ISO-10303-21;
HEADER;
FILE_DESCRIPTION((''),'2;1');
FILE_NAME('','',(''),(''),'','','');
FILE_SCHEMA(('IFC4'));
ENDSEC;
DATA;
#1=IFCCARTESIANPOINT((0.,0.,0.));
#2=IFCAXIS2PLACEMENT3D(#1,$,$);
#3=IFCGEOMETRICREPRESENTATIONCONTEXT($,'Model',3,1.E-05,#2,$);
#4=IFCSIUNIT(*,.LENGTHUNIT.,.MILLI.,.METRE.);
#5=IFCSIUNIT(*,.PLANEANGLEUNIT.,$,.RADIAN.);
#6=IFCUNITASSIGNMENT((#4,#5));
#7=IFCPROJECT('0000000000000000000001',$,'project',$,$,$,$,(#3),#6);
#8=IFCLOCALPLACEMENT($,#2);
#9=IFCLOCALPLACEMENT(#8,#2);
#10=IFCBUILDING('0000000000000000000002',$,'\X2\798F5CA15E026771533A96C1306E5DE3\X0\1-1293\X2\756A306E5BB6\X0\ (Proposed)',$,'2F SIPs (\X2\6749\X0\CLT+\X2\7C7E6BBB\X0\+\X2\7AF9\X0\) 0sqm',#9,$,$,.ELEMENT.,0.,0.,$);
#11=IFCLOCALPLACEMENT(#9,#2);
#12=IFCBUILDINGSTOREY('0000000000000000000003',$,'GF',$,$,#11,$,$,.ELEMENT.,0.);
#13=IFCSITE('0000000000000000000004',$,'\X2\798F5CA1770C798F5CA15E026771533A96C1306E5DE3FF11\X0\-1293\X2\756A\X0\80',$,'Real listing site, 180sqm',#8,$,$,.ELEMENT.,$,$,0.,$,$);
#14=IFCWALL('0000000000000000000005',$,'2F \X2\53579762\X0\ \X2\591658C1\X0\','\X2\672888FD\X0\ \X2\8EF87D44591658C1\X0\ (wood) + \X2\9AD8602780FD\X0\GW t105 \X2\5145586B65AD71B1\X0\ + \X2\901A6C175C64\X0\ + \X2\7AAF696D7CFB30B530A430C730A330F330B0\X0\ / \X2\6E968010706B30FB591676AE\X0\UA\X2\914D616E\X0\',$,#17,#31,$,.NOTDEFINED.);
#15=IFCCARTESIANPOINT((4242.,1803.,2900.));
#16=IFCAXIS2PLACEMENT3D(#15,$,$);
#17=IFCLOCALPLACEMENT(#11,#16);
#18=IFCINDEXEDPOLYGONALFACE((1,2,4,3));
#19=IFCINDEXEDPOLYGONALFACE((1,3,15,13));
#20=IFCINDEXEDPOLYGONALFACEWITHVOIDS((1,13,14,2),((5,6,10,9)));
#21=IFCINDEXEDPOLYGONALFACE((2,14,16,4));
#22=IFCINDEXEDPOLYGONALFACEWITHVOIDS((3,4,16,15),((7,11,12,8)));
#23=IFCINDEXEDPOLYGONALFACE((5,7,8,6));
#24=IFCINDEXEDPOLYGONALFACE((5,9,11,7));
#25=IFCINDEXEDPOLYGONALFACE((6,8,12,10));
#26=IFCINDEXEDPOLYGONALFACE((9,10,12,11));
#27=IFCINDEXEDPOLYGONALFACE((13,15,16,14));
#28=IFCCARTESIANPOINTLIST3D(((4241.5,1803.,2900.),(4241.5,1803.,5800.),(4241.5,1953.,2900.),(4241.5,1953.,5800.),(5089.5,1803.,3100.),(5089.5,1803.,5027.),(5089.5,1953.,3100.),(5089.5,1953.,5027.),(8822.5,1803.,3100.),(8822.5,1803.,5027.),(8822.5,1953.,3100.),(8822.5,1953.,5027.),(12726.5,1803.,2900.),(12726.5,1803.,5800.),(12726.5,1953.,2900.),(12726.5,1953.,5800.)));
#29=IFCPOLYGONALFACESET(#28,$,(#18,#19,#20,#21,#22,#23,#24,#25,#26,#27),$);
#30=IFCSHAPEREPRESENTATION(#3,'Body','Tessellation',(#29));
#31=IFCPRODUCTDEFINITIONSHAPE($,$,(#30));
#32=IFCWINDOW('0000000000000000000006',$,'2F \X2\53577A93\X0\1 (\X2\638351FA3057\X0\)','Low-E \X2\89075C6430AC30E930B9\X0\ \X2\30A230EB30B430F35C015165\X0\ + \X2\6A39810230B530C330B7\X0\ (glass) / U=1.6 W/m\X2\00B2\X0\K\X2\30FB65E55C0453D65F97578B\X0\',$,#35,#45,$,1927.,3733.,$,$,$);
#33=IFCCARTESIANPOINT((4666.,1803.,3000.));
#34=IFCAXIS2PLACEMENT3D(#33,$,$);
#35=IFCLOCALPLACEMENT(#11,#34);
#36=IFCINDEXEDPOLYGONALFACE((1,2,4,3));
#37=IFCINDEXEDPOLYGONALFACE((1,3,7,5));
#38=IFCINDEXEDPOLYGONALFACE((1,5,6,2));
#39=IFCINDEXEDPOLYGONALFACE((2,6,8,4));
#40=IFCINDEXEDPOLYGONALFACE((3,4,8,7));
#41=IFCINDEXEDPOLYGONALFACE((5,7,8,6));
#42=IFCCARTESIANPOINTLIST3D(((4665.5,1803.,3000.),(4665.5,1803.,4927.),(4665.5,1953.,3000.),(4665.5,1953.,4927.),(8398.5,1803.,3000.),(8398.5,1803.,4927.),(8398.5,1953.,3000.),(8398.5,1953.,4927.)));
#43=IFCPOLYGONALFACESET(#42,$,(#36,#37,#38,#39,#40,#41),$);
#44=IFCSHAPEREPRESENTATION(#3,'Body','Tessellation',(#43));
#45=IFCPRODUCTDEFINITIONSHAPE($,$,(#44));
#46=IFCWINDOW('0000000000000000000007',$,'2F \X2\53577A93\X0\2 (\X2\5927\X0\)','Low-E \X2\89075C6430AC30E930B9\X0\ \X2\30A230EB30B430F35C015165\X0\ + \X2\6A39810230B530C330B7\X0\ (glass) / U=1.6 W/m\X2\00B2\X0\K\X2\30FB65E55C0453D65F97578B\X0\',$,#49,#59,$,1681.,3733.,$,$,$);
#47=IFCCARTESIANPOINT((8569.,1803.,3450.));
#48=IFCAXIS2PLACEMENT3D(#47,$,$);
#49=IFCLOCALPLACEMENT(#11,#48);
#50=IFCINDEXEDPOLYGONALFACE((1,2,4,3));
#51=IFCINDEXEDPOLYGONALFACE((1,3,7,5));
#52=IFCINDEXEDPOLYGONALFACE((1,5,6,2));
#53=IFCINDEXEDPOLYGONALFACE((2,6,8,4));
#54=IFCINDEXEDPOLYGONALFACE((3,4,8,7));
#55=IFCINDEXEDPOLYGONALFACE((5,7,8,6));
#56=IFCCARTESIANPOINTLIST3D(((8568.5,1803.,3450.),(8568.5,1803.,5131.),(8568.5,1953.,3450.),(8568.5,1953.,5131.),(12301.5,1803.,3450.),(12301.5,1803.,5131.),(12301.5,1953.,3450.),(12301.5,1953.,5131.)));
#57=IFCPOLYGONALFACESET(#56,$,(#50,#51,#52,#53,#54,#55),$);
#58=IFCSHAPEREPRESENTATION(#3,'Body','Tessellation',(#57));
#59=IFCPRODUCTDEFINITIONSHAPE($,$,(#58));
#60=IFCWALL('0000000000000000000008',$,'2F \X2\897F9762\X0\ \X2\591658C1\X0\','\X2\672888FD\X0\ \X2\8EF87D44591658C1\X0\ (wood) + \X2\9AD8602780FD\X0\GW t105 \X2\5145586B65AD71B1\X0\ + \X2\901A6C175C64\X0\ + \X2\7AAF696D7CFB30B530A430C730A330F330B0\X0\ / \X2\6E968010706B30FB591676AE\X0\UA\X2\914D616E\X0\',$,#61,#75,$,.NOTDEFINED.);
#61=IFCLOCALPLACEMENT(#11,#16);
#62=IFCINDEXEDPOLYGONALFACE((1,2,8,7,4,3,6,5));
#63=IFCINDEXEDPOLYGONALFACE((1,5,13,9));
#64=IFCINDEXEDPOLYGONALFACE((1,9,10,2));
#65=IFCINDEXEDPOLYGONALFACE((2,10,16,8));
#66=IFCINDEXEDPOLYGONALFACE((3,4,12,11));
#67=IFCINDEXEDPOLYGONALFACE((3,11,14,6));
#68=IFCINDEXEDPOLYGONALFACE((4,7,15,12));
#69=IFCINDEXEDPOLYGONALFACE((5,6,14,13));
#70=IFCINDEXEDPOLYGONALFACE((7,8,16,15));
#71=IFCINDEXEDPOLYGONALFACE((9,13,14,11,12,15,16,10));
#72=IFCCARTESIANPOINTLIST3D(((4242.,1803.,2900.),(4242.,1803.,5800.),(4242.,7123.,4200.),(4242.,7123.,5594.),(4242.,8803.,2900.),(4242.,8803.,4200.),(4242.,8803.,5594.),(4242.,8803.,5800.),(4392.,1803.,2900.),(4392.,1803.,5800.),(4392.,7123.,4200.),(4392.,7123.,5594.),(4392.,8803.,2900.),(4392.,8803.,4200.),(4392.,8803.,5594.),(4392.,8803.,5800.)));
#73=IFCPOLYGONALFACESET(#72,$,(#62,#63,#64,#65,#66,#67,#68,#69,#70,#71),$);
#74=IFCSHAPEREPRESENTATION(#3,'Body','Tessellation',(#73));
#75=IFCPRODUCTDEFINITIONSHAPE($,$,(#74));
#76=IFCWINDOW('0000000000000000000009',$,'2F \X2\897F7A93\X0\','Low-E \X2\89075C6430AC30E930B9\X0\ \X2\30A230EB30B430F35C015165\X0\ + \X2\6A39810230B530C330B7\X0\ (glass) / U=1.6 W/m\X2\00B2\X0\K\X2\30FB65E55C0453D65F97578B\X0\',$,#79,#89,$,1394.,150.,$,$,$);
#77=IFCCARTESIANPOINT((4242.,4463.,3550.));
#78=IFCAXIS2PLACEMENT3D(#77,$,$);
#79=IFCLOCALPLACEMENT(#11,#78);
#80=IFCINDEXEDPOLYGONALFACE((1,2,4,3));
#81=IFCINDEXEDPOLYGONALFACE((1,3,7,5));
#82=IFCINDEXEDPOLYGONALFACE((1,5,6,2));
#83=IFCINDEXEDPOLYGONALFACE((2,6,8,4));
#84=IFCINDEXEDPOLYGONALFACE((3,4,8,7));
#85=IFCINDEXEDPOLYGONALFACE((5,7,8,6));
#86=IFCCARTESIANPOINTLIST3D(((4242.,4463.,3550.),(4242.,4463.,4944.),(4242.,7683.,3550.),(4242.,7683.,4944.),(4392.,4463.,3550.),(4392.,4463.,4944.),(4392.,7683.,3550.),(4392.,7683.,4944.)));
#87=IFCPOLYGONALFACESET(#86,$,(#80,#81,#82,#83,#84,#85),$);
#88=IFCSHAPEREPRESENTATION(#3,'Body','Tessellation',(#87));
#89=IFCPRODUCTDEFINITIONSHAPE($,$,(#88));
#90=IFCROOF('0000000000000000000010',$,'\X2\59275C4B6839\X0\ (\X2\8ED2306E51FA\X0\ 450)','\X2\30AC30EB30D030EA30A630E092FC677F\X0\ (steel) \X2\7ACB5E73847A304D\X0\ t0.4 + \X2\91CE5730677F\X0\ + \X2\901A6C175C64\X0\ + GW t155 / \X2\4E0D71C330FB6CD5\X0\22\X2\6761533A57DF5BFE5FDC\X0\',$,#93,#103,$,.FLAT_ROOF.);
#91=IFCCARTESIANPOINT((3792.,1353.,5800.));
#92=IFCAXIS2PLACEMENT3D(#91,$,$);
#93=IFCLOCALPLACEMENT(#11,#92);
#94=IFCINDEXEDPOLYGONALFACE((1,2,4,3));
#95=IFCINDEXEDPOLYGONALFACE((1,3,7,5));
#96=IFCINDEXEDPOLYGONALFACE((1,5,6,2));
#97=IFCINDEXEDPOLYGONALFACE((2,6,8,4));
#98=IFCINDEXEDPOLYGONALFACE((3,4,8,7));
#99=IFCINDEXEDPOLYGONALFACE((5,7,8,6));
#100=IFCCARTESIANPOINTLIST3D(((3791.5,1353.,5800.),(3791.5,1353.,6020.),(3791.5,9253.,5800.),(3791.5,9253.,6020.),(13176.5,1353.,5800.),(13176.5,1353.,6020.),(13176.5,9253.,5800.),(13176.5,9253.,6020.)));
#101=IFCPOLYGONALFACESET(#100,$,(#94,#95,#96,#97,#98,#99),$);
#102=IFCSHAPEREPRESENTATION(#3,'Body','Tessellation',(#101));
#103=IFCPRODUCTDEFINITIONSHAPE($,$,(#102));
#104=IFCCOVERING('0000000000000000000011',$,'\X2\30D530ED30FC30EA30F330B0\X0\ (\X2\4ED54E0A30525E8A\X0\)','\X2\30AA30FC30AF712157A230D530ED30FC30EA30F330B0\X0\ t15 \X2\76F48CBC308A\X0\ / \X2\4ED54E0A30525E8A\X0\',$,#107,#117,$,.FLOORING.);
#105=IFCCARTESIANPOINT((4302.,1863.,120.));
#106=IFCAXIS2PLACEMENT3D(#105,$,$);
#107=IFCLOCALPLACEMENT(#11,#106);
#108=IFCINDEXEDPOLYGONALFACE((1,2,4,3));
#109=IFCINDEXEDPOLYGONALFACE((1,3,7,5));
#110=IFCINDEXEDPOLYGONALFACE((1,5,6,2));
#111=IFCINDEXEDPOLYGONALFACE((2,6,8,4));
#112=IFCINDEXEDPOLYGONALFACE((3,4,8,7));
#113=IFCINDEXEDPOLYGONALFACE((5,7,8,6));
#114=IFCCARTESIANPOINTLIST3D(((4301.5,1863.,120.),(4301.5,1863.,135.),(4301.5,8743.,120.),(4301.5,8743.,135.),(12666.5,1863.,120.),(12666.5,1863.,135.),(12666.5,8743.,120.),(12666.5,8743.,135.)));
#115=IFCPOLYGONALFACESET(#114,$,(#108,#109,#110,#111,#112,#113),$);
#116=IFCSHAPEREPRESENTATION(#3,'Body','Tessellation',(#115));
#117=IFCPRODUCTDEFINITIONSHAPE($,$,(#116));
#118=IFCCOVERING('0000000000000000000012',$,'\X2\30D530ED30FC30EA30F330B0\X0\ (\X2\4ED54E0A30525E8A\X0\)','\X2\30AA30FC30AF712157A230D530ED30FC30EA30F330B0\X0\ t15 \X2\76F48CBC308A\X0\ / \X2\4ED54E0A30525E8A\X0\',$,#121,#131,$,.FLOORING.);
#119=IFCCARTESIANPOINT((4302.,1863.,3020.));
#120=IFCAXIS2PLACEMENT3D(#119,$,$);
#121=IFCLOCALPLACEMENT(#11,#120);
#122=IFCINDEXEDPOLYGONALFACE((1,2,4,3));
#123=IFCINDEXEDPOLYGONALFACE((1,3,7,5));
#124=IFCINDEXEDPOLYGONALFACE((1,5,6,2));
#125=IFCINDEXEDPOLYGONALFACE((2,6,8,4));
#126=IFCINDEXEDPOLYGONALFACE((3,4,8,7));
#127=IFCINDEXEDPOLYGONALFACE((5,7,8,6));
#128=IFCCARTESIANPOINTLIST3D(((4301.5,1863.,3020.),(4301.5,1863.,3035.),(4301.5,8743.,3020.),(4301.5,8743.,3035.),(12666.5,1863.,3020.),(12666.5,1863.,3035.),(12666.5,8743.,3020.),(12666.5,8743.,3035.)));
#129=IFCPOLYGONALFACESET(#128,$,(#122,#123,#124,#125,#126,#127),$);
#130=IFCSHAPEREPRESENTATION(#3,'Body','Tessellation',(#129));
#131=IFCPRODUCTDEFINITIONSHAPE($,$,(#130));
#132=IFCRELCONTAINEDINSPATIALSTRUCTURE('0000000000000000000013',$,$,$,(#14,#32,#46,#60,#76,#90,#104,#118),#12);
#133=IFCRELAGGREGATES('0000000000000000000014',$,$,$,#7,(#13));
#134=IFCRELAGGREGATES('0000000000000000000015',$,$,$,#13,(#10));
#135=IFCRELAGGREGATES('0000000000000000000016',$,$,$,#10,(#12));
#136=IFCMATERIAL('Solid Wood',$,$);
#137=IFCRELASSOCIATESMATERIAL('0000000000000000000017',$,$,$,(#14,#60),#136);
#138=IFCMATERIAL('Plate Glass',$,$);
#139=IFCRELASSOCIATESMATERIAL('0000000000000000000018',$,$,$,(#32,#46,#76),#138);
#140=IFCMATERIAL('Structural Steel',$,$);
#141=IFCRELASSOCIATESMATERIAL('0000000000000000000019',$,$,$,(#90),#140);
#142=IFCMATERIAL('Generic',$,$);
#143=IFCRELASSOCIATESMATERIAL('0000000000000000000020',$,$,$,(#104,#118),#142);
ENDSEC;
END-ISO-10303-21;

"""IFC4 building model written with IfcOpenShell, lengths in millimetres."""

from ifc_helpers import new_model, si_unit, frame, frame_2d, origin, place, context, project, spatial, rectangle, extrude, material, element, fill, save


model = new_model("IFC4")

# Units and contexts
model_context = context("Model", 3, precision=1e-05, world=origin())
ifc_project = project(units=[si_unit("LENGTHUNIT", "METRE", prefix="MILLI"), si_unit("PLANEANGLEUNIT", "RADIAN")], contexts=[model_context])

# Site, building, storey
site_placement = place(None, origin())
site = spatial("IfcSite", under=ifc_project, at=site_placement, Name="福岡県福岡市東区雁の巣１-1293番80", ObjectType="Real listing site, 180sqm", CompositionType="ELEMENT", RefElevation=0.0)
building_placement = place(site_placement, origin())
building = spatial("IfcBuilding", under=site, at=building_placement, Name="福岡市東区雁の巣1-1293番の家 (Proposed)", ObjectType="2F SIPs (杉CLT+籾殻+竹) 0sqm", CompositionType="ELEMENT", ElevationOfRefHeight=0.0, ElevationOfTerrain=0.0)
storey_placement = place(building_placement, origin())
storey = spatial("IfcBuildingStorey", under=building, at=storey_placement, Name="GF", CompositionType="ELEMENT", Elevation=0.0)

# Shared definitions
ifc_material_1 = material(Name="Solid Wood")

# Shared definitions
ifc_material_2 = material(Name="Plate Glass")

# Wall, openings, windows
wall_1_placement = place(storey_placement, frame((4242.0, 1803.0, 2900.0)))
wall_1 = element("IfcWall", 1, at=wall_1_placement, inside=storey, material=ifc_material_1, Name="2F 南面 外壁", Description="木製 軸組外壁 (wood) + 高性能GW t105 充填断熱 + 通気層 + 窯業系サイディング / 準耐火・外皮UA配慮", PredefinedType="NOTDEFINED", context=model_context, shape_type="SweptSolid", body=[
    extrude(rectangle(XDim=8485.0, YDim=150.0, at=frame_2d((4242.0, 75.0))), frame((4242.0, 1803.0, 2900.0)), (0.0, 0.0, 1.0), 2900.0),
])
opening_1_placement = place(storey_placement, frame((4666.0, 1803.0, 3000.0)))
opening_1 = element("IfcOpeningElement", 2, at=opening_1_placement, cuts=wall_1, PredefinedType="NOTDEFINED", context=model_context, shape_type="SweptSolid", body=[
    extrude(rectangle(XDim=3733.0, YDim=150.0, at=frame_2d((1866.0, 75.0))), frame((4666.0, 1803.0, 3000.0)), (0.0, 0.0, 1.0), 1927.0),
])
opening_2_placement = place(storey_placement, frame((8569.0, 1803.0, 3450.0)))
opening_2 = element("IfcOpeningElement", 3, at=opening_2_placement, cuts=wall_1, PredefinedType="NOTDEFINED", context=model_context, shape_type="SweptSolid", body=[
    extrude(rectangle(XDim=3733.0, YDim=150.0, at=frame_2d((1866.0, 75.0))), frame((8569.0, 1803.0, 3450.0)), (0.0, 0.0, 1.0), 1681.0),
])
window_1_placement = place(storey_placement, frame((4666.0, 1803.0, 3000.0)))
window_1 = element("IfcWindow", 4, at=window_1_placement, inside=storey, material=ifc_material_2, Name="2F 南窓1 (掃出し)", Description="Low-E 複層ガラス アルゴン封入 + 樹脂サッシ (glass) / U=1.6 W/m²K・日射取得型", OverallHeight=1927.0, OverallWidth=3733.0, context=model_context, shape_type="SweptSolid", body=[
    extrude(rectangle(XDim=3733.0, YDim=150.0, at=frame_2d((1866.0, 75.0))), frame((4666.0, 1803.0, 3000.0)), (0.0, 0.0, 1.0), 1927.0),
])
fill(opening_1, window_1)
window_2_placement = place(storey_placement, frame((8569.0, 1803.0, 3450.0)))
window_2 = element("IfcWindow", 5, at=window_2_placement, inside=storey, material=ifc_material_2, Name="2F 南窓2 (大)", Description="Low-E 複層ガラス アルゴン封入 + 樹脂サッシ (glass) / U=1.6 W/m²K・日射取得型", OverallHeight=1681.0, OverallWidth=3733.0, context=model_context, shape_type="SweptSolid", body=[
    extrude(rectangle(XDim=3733.0, YDim=150.0, at=frame_2d((1866.0, 75.0))), frame((8569.0, 1803.0, 3450.0)), (0.0, 0.0, 1.0), 1681.0),
])
fill(opening_2, window_2)

# Wall, opening, window
wall_2_placement = place(storey_placement, frame((4242.0, 1803.0, 2900.0)))
wall_2 = element("IfcWall", 6, at=wall_2_placement, inside=storey, material=ifc_material_1, Name="2F 西面 外壁", Description="木製 軸組外壁 (wood) + 高性能GW t105 充填断熱 + 通気層 + 窯業系サイディング / 準耐火・外皮UA配慮", PredefinedType="NOTDEFINED", context=model_context, shape_type="SweptSolid", body=[
    extrude(rectangle(XDim=150.0, YDim=7000.0, at=frame_2d((75.0, 3500.0))), frame((4242.0, 1803.0, 2900.0)), (0.0, 0.0, 1.0), 2900.0),
])
opening_3_placement = place(storey_placement, frame((4242.0, 4463.0, 3550.0)))
opening_3 = element("IfcOpeningElement", 7, at=opening_3_placement, cuts=wall_2, PredefinedType="NOTDEFINED", context=model_context, shape_type="SweptSolid", body=[
    extrude(rectangle(XDim=150.0, YDim=3220.0, at=frame_2d((75.0, 1610.0))), frame((4242.0, 4463.0, 3550.0)), (0.0, 0.0, 1.0), 1394.0),
])
window_3_placement = place(storey_placement, frame((4242.0, 4463.0, 3550.0)))
window_3 = element("IfcWindow", 8, at=window_3_placement, inside=storey, material=ifc_material_2, Name="2F 西窓", Description="Low-E 複層ガラス アルゴン封入 + 樹脂サッシ (glass) / U=1.6 W/m²K・日射取得型", OverallHeight=1394.0, OverallWidth=150.0, context=model_context, shape_type="SweptSolid", body=[
    extrude(rectangle(XDim=150.0, YDim=3220.0, at=frame_2d((75.0, 1610.0))), frame((4242.0, 4463.0, 3550.0)), (0.0, 0.0, 1.0), 1394.0),
])
fill(opening_3, window_3)

# Roof
ifc_material_3 = material(Name="Structural Steel")
roof_placement = place(storey_placement, frame((3792.0, 1353.0, 5800.0)))
element("IfcRoof", 9, at=roof_placement, inside=storey, material=ifc_material_3, Name="大屋根 (軒の出 450)", Description="ガルバリウム鋼板 (steel) 立平葺き t0.4 + 野地板 + 通気層 + GW t155 / 不燃・法22条区域対応", PredefinedType="FLAT_ROOF", context=model_context, shape_type="SweptSolid", body=[
    extrude(rectangle(XDim=9385.0, YDim=7900.0, at=frame_2d((4692.0, 3950.0))), frame((3792.0, 1353.0, 5800.0)), (0.0, 0.0, 1.0), 220.0),
])

# Coverings
ifc_material_4 = material(Name="Generic")
covering_1_placement = place(storey_placement, frame((4302.0, 1863.0, 120.0)))
element("IfcCovering", 10, at=covering_1_placement, inside=storey, material=ifc_material_4, Name="フローリング (仕上げ床)", Description="オーク無垢フローリング t15 直貼り / 仕上げ床", PredefinedType="FLOORING", context=model_context, shape_type="SweptSolid", body=[
    extrude(rectangle(XDim=8365.0, YDim=6880.0, at=frame_2d((4182.0, 3440.0))), frame((4302.0, 1863.0, 120.0)), (0.0, 0.0, 1.0), 15.0),
])
covering_2_placement = place(storey_placement, frame((4302.0, 1863.0, 3020.0)))
element("IfcCovering", 11, at=covering_2_placement, inside=storey, material=ifc_material_4, Name="フローリング (仕上げ床)", Description="オーク無垢フローリング t15 直貼り / 仕上げ床", PredefinedType="FLOORING", context=model_context, shape_type="SweptSolid", body=[
    extrude(rectangle(XDim=8365.0, YDim=6880.0, at=frame_2d((4182.0, 3440.0))), frame((4302.0, 1863.0, 3020.0)), (0.0, 0.0, 1.0), 15.0),
])

save(model, "model.ifc")
